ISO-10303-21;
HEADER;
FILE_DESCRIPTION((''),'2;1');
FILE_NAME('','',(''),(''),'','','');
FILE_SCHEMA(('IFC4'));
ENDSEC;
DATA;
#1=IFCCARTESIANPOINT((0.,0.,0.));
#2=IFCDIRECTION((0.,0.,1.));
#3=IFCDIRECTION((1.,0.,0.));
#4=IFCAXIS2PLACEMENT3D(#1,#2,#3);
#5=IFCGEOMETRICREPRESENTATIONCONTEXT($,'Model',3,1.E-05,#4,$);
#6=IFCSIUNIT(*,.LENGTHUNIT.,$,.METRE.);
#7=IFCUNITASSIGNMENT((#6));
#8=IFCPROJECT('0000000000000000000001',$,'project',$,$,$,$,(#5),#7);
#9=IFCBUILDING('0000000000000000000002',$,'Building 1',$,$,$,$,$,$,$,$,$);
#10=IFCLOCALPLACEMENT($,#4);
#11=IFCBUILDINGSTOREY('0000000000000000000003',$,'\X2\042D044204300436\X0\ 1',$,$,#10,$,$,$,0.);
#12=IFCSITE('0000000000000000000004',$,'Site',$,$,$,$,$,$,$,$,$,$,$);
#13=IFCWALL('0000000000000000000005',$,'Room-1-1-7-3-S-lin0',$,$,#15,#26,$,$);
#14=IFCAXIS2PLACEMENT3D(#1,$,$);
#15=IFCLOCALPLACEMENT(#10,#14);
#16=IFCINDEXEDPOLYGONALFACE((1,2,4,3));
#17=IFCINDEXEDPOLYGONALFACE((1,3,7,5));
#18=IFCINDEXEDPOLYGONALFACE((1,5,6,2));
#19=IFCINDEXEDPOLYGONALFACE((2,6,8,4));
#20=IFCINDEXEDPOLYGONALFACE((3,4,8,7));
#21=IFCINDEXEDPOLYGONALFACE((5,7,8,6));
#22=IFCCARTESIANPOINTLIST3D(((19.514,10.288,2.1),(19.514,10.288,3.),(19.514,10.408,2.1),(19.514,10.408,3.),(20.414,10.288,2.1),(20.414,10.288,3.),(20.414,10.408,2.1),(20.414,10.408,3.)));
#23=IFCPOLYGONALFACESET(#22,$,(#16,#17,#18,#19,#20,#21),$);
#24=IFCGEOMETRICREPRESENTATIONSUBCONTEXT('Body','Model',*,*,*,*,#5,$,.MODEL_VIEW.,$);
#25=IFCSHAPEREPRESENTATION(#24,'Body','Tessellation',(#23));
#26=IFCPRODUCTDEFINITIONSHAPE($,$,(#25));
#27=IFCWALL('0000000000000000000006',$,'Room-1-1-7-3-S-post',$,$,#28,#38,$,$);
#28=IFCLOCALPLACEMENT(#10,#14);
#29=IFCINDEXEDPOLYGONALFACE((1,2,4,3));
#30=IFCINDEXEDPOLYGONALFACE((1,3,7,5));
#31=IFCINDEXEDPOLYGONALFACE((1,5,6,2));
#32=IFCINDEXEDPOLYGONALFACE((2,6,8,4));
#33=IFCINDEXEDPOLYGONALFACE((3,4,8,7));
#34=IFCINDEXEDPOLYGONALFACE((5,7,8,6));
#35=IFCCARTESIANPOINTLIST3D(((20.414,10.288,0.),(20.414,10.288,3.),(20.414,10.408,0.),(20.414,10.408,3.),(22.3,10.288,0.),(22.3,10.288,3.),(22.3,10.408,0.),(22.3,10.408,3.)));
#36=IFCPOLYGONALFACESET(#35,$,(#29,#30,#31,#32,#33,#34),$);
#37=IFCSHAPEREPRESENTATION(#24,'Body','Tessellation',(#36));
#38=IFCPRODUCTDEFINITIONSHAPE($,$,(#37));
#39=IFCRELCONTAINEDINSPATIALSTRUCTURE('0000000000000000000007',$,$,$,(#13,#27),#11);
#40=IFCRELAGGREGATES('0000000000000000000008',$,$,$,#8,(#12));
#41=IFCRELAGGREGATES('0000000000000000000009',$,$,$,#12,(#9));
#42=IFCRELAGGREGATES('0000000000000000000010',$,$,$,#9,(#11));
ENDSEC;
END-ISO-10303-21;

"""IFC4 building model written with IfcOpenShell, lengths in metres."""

from ifc_helpers import new_model, si_unit, frame, origin_with_axes, place, context, subcontext, project, spatial, indexed_curve, outline, extrude, element, save


model = new_model("IFC4")

# Units and contexts
model_context = context("Model", 3, precision=1e-05, world=origin_with_axes())
body_context = subcontext(model_context, "Body", "Model", "MODEL_VIEW")
ifc_project = project(units=[si_unit("LENGTHUNIT", "METRE")], contexts=[model_context])

# Site, building, storey
site = spatial("IfcSite", under=ifc_project, Name="Site")
building = spatial("IfcBuilding", under=site, Name="Building 1")
storey_placement = place(None, origin_with_axes())
storey = spatial("IfcBuildingStorey", under=building, at=storey_placement, Name="Этаж 1", Elevation=0.0)

# Walls
wall_1_placement = place(storey_placement, frame((19.514, 10.288, 2.1), z_axis=(0.0, 0.0, 1.0), x_axis=(1.0, 0.0, 0.0)))
element("IfcWall", 1, at=wall_1_placement, inside=storey, Name="Room-1-1-7-3-S-lin0", context=body_context, shape_type="SweptSolid", body=[
    extrude(outline(indexed_curve([(0.0, 0.0), (0.0, 0.12), (0.9, 0.12), (0.9, 0.0), (0.0, 0.0)], self_intersect=False)), origin_with_axes(), (0.0, 0.0, 1.0), 0.9),
])
wall_2_placement = place(storey_placement, frame((20.414, 10.288, 0.0), z_axis=(0.0, 0.0, 1.0), x_axis=(1.0, 0.0, 0.0)))
element("IfcWall", 2, at=wall_2_placement, inside=storey, Name="Room-1-1-7-3-S-post", context=body_context, shape_type="SweptSolid", body=[
    extrude(outline(indexed_curve([(0.0, 0.0), (0.0, 0.12), (1.886, 0.12), (1.886, 0.0), (0.0, 0.0)], self_intersect=False)), origin_with_axes(), (0.0, 0.0, 1.0), 3.0),
])

save(model, "model.ifc")
